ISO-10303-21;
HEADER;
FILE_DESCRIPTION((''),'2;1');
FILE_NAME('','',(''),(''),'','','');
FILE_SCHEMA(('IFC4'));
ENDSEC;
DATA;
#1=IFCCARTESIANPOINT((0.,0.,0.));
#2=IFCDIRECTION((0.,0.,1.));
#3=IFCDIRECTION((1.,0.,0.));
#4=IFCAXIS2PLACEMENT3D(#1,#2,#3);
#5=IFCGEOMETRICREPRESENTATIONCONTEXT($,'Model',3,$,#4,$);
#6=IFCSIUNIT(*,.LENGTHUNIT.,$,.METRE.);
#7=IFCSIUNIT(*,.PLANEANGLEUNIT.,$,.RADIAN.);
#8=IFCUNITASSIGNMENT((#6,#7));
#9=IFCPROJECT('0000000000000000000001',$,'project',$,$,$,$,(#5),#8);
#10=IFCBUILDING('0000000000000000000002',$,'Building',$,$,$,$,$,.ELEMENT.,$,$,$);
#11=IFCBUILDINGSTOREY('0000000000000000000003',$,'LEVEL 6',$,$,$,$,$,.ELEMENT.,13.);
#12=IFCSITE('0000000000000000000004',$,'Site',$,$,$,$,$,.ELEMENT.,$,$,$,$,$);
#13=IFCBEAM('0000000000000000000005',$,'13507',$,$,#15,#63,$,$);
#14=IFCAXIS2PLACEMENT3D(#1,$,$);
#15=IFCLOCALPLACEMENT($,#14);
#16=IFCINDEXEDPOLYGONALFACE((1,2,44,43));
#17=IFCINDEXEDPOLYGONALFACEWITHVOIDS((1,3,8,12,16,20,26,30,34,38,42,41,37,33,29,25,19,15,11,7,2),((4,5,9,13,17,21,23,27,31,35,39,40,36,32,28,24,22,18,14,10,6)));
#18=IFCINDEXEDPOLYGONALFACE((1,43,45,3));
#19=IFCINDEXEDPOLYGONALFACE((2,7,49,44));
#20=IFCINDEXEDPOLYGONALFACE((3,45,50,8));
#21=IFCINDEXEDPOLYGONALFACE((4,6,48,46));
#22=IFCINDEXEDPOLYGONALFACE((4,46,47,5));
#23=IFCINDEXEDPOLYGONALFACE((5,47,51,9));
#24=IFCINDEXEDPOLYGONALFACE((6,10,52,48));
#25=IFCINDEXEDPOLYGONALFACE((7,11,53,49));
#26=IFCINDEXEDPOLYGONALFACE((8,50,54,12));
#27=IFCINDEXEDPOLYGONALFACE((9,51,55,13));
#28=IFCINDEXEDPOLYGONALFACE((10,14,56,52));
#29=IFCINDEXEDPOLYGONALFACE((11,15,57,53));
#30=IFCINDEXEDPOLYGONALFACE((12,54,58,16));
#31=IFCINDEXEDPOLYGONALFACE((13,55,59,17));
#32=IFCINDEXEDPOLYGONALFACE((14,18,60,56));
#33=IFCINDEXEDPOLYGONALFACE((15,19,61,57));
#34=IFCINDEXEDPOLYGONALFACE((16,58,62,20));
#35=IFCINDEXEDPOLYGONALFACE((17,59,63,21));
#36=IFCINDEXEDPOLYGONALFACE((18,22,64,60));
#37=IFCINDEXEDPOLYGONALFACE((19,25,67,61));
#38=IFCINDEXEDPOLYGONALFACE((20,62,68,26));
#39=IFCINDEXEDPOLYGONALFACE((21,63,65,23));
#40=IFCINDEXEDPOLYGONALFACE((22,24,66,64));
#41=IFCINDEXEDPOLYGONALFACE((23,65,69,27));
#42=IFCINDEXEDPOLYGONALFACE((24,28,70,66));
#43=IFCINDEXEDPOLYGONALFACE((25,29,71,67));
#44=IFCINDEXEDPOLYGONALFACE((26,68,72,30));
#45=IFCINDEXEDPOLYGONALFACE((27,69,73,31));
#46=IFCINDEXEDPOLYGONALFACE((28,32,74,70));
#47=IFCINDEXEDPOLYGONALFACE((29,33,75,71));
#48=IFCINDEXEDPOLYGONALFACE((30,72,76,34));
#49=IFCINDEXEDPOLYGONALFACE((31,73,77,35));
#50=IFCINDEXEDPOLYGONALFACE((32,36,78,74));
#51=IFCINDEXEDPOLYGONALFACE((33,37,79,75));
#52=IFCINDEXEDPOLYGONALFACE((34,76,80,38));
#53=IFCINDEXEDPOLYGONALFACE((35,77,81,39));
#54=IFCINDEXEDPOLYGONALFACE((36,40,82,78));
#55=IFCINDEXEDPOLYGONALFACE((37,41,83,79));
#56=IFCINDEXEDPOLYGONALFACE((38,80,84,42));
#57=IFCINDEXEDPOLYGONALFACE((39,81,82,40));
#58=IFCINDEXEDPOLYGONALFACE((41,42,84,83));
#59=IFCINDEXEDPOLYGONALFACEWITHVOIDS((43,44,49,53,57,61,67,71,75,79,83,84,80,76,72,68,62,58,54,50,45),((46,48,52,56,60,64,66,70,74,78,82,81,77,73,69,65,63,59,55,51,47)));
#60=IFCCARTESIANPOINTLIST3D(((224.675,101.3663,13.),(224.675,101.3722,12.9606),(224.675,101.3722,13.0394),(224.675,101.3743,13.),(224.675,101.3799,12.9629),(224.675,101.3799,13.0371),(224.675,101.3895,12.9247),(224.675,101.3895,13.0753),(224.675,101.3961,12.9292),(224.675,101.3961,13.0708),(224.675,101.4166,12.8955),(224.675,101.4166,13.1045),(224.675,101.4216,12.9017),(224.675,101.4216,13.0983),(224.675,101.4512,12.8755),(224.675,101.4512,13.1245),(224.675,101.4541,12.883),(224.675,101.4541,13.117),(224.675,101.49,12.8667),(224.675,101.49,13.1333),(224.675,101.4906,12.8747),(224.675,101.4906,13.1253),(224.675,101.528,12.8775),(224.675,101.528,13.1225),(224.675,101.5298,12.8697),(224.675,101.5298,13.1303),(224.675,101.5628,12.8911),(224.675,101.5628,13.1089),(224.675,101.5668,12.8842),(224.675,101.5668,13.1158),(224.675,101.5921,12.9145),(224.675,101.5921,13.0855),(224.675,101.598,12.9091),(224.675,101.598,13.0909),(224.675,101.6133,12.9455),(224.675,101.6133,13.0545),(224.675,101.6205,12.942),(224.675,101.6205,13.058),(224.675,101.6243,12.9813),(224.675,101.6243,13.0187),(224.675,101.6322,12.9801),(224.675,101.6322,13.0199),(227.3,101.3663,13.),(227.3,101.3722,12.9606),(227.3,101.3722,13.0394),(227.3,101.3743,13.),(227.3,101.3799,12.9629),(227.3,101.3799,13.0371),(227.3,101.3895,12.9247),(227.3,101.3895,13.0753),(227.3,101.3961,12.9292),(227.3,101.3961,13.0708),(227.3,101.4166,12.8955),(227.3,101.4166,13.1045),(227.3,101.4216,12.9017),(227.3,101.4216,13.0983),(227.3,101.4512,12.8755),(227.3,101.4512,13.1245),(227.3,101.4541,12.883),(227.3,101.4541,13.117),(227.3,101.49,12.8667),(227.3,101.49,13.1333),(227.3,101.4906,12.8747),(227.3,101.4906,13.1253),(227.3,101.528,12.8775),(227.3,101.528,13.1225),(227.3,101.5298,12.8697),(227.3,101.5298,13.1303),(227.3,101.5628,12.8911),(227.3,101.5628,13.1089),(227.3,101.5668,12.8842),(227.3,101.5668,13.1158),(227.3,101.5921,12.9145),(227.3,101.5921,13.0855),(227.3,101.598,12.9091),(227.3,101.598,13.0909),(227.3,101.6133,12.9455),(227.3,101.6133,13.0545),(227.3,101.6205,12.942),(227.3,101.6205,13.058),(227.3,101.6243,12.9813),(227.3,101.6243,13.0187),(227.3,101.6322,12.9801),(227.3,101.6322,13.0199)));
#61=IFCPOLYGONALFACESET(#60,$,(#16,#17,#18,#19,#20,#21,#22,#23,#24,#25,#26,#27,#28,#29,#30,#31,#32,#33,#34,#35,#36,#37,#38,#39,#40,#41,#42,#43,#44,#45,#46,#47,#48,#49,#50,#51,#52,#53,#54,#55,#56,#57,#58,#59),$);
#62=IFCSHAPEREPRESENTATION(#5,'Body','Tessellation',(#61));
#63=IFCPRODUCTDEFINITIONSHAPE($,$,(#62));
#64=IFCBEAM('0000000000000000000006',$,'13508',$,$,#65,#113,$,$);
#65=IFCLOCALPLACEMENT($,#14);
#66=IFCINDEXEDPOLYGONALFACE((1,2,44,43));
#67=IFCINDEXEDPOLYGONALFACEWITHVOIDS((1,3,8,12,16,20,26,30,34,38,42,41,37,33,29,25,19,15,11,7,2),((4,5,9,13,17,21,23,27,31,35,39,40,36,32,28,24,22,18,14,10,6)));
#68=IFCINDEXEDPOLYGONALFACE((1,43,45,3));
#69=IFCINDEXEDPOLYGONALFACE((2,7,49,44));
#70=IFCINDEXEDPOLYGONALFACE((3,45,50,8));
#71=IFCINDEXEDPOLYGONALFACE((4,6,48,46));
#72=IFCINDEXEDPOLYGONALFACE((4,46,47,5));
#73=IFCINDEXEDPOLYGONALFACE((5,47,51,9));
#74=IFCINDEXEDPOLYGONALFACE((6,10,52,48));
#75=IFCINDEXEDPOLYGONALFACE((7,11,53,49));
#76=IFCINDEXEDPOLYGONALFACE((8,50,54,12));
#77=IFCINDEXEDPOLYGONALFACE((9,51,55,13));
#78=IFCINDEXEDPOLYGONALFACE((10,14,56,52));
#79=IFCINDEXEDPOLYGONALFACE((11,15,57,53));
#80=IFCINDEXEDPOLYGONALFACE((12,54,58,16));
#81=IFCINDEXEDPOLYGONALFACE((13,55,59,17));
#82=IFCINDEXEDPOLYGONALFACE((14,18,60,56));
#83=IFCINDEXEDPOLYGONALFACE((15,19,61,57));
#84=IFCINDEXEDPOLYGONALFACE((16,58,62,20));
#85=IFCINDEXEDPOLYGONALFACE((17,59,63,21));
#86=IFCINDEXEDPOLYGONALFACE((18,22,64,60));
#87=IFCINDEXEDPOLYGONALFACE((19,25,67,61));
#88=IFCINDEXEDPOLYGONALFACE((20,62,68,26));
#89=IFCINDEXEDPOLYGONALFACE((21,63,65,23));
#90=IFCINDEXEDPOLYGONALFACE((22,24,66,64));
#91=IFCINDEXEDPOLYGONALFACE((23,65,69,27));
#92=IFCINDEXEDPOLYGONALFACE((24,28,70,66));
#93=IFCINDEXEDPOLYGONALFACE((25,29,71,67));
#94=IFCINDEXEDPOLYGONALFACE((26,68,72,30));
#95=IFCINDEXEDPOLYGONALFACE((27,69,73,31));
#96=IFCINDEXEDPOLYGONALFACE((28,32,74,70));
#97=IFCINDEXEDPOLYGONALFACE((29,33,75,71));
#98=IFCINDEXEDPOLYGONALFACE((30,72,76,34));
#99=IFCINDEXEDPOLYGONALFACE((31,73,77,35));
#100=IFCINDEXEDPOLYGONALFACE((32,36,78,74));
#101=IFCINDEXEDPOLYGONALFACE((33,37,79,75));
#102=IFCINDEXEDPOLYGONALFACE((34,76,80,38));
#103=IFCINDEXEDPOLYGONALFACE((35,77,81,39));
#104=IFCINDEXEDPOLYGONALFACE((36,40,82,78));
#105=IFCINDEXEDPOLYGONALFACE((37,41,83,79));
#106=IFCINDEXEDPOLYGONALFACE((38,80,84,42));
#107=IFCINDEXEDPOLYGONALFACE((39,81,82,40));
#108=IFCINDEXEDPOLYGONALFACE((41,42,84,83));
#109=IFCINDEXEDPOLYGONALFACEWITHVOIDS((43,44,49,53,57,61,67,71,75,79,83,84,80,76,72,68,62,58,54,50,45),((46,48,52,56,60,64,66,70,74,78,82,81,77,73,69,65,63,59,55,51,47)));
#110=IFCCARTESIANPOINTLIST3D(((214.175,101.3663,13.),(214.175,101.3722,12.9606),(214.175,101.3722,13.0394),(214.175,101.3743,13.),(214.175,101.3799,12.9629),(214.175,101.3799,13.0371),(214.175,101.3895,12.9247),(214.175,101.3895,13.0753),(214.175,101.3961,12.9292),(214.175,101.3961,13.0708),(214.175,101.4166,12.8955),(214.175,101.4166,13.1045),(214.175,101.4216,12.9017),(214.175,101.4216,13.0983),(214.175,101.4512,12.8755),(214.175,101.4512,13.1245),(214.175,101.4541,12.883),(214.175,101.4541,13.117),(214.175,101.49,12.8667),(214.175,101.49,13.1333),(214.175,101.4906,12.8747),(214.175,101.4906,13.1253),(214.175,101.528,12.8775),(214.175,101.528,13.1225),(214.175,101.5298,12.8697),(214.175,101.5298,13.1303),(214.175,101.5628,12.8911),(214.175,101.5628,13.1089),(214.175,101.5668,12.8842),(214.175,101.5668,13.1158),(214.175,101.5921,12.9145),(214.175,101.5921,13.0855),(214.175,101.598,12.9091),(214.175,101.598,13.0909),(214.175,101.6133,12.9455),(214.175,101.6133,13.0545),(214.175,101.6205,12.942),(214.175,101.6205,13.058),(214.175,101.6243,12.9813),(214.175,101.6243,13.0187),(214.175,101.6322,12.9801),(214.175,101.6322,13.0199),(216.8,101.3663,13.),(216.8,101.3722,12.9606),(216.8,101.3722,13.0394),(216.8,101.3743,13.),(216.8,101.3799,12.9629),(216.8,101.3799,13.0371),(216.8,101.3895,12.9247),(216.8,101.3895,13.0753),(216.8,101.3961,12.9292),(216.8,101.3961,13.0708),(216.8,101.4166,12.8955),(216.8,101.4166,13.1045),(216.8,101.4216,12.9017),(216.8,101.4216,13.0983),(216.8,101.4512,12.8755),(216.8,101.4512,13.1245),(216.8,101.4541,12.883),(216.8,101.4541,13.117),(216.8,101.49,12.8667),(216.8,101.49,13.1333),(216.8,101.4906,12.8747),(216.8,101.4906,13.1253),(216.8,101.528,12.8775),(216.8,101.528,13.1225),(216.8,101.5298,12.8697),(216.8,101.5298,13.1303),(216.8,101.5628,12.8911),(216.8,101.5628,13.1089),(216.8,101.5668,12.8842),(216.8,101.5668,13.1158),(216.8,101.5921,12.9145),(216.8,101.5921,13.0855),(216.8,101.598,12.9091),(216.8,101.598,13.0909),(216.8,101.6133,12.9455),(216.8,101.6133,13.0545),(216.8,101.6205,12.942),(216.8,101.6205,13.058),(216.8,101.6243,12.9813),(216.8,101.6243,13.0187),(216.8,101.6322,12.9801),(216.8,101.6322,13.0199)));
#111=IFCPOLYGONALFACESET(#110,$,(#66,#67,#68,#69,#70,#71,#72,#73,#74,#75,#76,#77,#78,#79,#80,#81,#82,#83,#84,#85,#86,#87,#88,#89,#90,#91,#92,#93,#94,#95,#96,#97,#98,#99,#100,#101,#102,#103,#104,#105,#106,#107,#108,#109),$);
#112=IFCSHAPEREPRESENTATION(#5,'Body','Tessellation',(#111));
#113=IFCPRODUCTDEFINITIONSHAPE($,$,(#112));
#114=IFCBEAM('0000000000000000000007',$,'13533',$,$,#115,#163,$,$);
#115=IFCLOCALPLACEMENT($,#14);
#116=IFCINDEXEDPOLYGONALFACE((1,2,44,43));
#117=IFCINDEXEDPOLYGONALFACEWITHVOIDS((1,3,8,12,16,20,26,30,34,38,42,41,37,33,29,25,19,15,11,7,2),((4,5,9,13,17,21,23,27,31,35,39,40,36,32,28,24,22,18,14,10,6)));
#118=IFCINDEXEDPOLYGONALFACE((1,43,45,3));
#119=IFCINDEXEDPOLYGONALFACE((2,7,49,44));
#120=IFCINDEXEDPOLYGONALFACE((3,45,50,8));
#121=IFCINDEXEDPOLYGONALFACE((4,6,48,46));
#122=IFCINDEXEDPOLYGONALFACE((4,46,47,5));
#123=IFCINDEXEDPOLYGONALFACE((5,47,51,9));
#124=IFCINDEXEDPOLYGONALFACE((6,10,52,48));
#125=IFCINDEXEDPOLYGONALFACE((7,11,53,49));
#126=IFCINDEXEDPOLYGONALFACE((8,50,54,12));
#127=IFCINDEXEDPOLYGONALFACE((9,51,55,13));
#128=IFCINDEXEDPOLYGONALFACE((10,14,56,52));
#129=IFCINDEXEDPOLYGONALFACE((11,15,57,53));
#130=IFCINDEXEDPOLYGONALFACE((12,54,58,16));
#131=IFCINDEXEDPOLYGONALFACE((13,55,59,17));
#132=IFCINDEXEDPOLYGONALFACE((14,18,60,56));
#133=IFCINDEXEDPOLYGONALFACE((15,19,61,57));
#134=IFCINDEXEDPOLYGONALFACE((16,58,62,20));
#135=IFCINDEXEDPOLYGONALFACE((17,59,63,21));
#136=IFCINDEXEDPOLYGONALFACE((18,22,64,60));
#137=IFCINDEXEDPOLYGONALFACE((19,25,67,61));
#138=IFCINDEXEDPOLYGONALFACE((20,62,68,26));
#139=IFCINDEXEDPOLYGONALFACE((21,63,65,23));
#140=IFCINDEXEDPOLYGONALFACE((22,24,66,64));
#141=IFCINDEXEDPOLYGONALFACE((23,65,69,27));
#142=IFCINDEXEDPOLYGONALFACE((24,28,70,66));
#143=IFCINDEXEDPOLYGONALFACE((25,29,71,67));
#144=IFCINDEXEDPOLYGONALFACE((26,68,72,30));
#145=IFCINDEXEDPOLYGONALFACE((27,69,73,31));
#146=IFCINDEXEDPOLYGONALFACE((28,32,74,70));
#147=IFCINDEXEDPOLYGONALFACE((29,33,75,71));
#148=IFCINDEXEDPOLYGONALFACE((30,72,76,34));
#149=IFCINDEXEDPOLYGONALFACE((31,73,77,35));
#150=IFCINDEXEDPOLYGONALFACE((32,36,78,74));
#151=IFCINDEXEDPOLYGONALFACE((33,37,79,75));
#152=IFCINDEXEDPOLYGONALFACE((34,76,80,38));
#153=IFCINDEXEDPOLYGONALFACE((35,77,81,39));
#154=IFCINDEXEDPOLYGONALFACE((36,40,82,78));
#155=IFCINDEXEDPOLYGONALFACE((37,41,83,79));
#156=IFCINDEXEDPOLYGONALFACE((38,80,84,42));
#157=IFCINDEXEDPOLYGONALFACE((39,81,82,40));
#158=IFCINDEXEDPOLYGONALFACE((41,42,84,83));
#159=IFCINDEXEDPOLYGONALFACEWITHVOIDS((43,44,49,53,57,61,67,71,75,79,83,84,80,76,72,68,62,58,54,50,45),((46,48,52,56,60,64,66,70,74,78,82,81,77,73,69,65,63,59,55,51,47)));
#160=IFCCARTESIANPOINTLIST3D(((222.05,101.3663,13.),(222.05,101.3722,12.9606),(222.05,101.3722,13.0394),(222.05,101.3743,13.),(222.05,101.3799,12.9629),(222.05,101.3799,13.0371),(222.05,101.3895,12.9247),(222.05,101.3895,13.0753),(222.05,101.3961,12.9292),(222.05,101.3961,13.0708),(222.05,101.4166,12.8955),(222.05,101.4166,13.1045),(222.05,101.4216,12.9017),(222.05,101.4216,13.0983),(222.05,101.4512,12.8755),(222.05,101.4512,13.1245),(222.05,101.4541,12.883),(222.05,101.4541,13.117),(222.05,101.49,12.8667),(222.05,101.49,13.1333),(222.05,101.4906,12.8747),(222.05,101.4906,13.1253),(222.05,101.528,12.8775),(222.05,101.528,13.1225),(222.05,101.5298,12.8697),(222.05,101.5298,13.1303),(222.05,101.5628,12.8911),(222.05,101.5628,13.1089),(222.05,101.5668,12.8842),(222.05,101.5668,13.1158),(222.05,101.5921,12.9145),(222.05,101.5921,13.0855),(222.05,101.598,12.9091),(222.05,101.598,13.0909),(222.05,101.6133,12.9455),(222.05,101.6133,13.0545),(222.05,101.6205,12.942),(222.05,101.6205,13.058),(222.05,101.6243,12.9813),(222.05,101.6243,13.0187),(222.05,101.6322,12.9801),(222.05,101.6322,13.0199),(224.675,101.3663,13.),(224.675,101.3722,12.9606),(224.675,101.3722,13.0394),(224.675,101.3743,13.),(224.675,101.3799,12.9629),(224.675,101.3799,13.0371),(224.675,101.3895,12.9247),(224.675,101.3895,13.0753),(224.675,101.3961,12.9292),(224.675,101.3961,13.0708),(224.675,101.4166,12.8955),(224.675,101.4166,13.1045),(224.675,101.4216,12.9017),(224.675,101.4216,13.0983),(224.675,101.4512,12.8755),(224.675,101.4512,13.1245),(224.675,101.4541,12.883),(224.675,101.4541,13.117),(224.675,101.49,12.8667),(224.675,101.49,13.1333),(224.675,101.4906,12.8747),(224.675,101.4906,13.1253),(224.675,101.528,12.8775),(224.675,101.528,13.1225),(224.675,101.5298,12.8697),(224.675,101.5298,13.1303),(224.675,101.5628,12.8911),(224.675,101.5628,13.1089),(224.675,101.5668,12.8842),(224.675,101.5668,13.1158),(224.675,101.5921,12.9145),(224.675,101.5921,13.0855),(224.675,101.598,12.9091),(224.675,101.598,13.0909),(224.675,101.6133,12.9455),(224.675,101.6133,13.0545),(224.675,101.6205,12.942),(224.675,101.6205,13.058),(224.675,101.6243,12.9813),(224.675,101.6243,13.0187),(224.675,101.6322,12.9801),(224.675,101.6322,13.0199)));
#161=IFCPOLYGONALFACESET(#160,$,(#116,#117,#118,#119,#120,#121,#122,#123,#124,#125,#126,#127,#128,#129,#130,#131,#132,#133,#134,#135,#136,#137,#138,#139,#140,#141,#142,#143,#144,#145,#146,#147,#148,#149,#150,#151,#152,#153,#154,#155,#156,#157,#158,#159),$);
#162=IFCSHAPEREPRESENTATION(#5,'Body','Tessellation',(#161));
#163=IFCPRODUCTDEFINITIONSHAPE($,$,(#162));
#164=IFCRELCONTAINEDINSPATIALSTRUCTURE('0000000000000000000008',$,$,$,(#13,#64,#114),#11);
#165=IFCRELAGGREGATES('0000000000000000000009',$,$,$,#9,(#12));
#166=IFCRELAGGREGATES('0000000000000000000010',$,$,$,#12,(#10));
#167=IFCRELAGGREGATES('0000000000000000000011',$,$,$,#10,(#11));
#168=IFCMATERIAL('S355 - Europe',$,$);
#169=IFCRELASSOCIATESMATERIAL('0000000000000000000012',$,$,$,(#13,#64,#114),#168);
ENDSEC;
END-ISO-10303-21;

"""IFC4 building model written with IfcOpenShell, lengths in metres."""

from ifc_helpers import new_model, si_unit, frame, origin_with_axes, origin_2d_with_axis, place, context, project, spatial, hollow_circle, extrude, material, material_profile, profile_set, profile_usage, element, save


model = new_model("IFC4")

# Units and contexts
model_context = context("Model", 3, world=origin_with_axes())
ifc_project = project(units=[si_unit("LENGTHUNIT", "METRE"), si_unit("PLANEANGLEUNIT", "RADIAN")], contexts=[model_context])

# Site, building, storey
site = spatial("IfcSite", under=ifc_project, Name="Site", CompositionType="ELEMENT")
building = spatial("IfcBuilding", under=site, Name="Building", CompositionType="ELEMENT")
storey = spatial("IfcBuildingStorey", under=building, Name="LEVEL 6", CompositionType="ELEMENT", Elevation=13.0)

# Shared definitions
ifc_material = material(Name="S355 - Europe")

# Beams
ifc_material_profile_1 = material_profile(ifc_material, hollow_circle(Radius=0.1337, WallThickness=0.008, at=origin_2d_with_axis()))
ifc_profile_set_1 = profile_set([ifc_material_profile_1])
ifc_profile_usage_1 = profile_usage(ifc_profile_set_1, cardinal=10)
beam_1_placement = place(None, frame((227.3, 101.5, 13.0), z_axis=(-1.0, 0.0, 0.0), x_axis=(0.0, -1.0, 0.0)))
element("IfcBeam", 1, at=beam_1_placement, inside=storey, material=ifc_profile_usage_1, Name="13507", context=model_context, shape_type="SweptSolid", body=[
    extrude(hollow_circle(Radius=0.1337, WallThickness=0.008, at=origin_2d_with_axis()), origin_with_axes(), (0.0, 0.0, 1.0), 2.625),
])
ifc_material_profile_2 = material_profile(ifc_material, hollow_circle(Radius=0.1337, WallThickness=0.008, at=origin_2d_with_axis()))
ifc_profile_set_2 = profile_set([ifc_material_profile_2])
ifc_profile_usage_2 = profile_usage(ifc_profile_set_2, cardinal=10)
beam_2_placement = place(None, frame((216.8, 101.5, 13.0), z_axis=(-1.0, 0.0, 0.0), x_axis=(0.0, -1.0, 0.0)))
element("IfcBeam", 2, at=beam_2_placement, inside=storey, material=ifc_profile_usage_2, Name="13508", context=model_context, shape_type="SweptSolid", body=[
    extrude(hollow_circle(Radius=0.1337, WallThickness=0.008, at=origin_2d_with_axis()), origin_with_axes(), (0.0, 0.0, 1.0), 2.625),
])
ifc_material_profile_3 = material_profile(ifc_material, hollow_circle(Radius=0.1337, WallThickness=0.008, at=origin_2d_with_axis()))
ifc_profile_set_3 = profile_set([ifc_material_profile_3])
ifc_profile_usage_3 = profile_usage(ifc_profile_set_3, cardinal=10)
beam_3_placement = place(None, frame((224.675, 101.5, 13.0), z_axis=(-1.0, 0.0, 0.0), x_axis=(0.0, -1.0, 0.0)))
element("IfcBeam", 3, at=beam_3_placement, inside=storey, material=ifc_profile_usage_3, Name="13533", context=model_context, shape_type="SweptSolid", body=[
    extrude(hollow_circle(Radius=0.1337, WallThickness=0.008, at=origin_2d_with_axis()), origin_with_axes(), (0.0, 0.0, 1.0), 2.625),
])

save(model, "model.ifc")
